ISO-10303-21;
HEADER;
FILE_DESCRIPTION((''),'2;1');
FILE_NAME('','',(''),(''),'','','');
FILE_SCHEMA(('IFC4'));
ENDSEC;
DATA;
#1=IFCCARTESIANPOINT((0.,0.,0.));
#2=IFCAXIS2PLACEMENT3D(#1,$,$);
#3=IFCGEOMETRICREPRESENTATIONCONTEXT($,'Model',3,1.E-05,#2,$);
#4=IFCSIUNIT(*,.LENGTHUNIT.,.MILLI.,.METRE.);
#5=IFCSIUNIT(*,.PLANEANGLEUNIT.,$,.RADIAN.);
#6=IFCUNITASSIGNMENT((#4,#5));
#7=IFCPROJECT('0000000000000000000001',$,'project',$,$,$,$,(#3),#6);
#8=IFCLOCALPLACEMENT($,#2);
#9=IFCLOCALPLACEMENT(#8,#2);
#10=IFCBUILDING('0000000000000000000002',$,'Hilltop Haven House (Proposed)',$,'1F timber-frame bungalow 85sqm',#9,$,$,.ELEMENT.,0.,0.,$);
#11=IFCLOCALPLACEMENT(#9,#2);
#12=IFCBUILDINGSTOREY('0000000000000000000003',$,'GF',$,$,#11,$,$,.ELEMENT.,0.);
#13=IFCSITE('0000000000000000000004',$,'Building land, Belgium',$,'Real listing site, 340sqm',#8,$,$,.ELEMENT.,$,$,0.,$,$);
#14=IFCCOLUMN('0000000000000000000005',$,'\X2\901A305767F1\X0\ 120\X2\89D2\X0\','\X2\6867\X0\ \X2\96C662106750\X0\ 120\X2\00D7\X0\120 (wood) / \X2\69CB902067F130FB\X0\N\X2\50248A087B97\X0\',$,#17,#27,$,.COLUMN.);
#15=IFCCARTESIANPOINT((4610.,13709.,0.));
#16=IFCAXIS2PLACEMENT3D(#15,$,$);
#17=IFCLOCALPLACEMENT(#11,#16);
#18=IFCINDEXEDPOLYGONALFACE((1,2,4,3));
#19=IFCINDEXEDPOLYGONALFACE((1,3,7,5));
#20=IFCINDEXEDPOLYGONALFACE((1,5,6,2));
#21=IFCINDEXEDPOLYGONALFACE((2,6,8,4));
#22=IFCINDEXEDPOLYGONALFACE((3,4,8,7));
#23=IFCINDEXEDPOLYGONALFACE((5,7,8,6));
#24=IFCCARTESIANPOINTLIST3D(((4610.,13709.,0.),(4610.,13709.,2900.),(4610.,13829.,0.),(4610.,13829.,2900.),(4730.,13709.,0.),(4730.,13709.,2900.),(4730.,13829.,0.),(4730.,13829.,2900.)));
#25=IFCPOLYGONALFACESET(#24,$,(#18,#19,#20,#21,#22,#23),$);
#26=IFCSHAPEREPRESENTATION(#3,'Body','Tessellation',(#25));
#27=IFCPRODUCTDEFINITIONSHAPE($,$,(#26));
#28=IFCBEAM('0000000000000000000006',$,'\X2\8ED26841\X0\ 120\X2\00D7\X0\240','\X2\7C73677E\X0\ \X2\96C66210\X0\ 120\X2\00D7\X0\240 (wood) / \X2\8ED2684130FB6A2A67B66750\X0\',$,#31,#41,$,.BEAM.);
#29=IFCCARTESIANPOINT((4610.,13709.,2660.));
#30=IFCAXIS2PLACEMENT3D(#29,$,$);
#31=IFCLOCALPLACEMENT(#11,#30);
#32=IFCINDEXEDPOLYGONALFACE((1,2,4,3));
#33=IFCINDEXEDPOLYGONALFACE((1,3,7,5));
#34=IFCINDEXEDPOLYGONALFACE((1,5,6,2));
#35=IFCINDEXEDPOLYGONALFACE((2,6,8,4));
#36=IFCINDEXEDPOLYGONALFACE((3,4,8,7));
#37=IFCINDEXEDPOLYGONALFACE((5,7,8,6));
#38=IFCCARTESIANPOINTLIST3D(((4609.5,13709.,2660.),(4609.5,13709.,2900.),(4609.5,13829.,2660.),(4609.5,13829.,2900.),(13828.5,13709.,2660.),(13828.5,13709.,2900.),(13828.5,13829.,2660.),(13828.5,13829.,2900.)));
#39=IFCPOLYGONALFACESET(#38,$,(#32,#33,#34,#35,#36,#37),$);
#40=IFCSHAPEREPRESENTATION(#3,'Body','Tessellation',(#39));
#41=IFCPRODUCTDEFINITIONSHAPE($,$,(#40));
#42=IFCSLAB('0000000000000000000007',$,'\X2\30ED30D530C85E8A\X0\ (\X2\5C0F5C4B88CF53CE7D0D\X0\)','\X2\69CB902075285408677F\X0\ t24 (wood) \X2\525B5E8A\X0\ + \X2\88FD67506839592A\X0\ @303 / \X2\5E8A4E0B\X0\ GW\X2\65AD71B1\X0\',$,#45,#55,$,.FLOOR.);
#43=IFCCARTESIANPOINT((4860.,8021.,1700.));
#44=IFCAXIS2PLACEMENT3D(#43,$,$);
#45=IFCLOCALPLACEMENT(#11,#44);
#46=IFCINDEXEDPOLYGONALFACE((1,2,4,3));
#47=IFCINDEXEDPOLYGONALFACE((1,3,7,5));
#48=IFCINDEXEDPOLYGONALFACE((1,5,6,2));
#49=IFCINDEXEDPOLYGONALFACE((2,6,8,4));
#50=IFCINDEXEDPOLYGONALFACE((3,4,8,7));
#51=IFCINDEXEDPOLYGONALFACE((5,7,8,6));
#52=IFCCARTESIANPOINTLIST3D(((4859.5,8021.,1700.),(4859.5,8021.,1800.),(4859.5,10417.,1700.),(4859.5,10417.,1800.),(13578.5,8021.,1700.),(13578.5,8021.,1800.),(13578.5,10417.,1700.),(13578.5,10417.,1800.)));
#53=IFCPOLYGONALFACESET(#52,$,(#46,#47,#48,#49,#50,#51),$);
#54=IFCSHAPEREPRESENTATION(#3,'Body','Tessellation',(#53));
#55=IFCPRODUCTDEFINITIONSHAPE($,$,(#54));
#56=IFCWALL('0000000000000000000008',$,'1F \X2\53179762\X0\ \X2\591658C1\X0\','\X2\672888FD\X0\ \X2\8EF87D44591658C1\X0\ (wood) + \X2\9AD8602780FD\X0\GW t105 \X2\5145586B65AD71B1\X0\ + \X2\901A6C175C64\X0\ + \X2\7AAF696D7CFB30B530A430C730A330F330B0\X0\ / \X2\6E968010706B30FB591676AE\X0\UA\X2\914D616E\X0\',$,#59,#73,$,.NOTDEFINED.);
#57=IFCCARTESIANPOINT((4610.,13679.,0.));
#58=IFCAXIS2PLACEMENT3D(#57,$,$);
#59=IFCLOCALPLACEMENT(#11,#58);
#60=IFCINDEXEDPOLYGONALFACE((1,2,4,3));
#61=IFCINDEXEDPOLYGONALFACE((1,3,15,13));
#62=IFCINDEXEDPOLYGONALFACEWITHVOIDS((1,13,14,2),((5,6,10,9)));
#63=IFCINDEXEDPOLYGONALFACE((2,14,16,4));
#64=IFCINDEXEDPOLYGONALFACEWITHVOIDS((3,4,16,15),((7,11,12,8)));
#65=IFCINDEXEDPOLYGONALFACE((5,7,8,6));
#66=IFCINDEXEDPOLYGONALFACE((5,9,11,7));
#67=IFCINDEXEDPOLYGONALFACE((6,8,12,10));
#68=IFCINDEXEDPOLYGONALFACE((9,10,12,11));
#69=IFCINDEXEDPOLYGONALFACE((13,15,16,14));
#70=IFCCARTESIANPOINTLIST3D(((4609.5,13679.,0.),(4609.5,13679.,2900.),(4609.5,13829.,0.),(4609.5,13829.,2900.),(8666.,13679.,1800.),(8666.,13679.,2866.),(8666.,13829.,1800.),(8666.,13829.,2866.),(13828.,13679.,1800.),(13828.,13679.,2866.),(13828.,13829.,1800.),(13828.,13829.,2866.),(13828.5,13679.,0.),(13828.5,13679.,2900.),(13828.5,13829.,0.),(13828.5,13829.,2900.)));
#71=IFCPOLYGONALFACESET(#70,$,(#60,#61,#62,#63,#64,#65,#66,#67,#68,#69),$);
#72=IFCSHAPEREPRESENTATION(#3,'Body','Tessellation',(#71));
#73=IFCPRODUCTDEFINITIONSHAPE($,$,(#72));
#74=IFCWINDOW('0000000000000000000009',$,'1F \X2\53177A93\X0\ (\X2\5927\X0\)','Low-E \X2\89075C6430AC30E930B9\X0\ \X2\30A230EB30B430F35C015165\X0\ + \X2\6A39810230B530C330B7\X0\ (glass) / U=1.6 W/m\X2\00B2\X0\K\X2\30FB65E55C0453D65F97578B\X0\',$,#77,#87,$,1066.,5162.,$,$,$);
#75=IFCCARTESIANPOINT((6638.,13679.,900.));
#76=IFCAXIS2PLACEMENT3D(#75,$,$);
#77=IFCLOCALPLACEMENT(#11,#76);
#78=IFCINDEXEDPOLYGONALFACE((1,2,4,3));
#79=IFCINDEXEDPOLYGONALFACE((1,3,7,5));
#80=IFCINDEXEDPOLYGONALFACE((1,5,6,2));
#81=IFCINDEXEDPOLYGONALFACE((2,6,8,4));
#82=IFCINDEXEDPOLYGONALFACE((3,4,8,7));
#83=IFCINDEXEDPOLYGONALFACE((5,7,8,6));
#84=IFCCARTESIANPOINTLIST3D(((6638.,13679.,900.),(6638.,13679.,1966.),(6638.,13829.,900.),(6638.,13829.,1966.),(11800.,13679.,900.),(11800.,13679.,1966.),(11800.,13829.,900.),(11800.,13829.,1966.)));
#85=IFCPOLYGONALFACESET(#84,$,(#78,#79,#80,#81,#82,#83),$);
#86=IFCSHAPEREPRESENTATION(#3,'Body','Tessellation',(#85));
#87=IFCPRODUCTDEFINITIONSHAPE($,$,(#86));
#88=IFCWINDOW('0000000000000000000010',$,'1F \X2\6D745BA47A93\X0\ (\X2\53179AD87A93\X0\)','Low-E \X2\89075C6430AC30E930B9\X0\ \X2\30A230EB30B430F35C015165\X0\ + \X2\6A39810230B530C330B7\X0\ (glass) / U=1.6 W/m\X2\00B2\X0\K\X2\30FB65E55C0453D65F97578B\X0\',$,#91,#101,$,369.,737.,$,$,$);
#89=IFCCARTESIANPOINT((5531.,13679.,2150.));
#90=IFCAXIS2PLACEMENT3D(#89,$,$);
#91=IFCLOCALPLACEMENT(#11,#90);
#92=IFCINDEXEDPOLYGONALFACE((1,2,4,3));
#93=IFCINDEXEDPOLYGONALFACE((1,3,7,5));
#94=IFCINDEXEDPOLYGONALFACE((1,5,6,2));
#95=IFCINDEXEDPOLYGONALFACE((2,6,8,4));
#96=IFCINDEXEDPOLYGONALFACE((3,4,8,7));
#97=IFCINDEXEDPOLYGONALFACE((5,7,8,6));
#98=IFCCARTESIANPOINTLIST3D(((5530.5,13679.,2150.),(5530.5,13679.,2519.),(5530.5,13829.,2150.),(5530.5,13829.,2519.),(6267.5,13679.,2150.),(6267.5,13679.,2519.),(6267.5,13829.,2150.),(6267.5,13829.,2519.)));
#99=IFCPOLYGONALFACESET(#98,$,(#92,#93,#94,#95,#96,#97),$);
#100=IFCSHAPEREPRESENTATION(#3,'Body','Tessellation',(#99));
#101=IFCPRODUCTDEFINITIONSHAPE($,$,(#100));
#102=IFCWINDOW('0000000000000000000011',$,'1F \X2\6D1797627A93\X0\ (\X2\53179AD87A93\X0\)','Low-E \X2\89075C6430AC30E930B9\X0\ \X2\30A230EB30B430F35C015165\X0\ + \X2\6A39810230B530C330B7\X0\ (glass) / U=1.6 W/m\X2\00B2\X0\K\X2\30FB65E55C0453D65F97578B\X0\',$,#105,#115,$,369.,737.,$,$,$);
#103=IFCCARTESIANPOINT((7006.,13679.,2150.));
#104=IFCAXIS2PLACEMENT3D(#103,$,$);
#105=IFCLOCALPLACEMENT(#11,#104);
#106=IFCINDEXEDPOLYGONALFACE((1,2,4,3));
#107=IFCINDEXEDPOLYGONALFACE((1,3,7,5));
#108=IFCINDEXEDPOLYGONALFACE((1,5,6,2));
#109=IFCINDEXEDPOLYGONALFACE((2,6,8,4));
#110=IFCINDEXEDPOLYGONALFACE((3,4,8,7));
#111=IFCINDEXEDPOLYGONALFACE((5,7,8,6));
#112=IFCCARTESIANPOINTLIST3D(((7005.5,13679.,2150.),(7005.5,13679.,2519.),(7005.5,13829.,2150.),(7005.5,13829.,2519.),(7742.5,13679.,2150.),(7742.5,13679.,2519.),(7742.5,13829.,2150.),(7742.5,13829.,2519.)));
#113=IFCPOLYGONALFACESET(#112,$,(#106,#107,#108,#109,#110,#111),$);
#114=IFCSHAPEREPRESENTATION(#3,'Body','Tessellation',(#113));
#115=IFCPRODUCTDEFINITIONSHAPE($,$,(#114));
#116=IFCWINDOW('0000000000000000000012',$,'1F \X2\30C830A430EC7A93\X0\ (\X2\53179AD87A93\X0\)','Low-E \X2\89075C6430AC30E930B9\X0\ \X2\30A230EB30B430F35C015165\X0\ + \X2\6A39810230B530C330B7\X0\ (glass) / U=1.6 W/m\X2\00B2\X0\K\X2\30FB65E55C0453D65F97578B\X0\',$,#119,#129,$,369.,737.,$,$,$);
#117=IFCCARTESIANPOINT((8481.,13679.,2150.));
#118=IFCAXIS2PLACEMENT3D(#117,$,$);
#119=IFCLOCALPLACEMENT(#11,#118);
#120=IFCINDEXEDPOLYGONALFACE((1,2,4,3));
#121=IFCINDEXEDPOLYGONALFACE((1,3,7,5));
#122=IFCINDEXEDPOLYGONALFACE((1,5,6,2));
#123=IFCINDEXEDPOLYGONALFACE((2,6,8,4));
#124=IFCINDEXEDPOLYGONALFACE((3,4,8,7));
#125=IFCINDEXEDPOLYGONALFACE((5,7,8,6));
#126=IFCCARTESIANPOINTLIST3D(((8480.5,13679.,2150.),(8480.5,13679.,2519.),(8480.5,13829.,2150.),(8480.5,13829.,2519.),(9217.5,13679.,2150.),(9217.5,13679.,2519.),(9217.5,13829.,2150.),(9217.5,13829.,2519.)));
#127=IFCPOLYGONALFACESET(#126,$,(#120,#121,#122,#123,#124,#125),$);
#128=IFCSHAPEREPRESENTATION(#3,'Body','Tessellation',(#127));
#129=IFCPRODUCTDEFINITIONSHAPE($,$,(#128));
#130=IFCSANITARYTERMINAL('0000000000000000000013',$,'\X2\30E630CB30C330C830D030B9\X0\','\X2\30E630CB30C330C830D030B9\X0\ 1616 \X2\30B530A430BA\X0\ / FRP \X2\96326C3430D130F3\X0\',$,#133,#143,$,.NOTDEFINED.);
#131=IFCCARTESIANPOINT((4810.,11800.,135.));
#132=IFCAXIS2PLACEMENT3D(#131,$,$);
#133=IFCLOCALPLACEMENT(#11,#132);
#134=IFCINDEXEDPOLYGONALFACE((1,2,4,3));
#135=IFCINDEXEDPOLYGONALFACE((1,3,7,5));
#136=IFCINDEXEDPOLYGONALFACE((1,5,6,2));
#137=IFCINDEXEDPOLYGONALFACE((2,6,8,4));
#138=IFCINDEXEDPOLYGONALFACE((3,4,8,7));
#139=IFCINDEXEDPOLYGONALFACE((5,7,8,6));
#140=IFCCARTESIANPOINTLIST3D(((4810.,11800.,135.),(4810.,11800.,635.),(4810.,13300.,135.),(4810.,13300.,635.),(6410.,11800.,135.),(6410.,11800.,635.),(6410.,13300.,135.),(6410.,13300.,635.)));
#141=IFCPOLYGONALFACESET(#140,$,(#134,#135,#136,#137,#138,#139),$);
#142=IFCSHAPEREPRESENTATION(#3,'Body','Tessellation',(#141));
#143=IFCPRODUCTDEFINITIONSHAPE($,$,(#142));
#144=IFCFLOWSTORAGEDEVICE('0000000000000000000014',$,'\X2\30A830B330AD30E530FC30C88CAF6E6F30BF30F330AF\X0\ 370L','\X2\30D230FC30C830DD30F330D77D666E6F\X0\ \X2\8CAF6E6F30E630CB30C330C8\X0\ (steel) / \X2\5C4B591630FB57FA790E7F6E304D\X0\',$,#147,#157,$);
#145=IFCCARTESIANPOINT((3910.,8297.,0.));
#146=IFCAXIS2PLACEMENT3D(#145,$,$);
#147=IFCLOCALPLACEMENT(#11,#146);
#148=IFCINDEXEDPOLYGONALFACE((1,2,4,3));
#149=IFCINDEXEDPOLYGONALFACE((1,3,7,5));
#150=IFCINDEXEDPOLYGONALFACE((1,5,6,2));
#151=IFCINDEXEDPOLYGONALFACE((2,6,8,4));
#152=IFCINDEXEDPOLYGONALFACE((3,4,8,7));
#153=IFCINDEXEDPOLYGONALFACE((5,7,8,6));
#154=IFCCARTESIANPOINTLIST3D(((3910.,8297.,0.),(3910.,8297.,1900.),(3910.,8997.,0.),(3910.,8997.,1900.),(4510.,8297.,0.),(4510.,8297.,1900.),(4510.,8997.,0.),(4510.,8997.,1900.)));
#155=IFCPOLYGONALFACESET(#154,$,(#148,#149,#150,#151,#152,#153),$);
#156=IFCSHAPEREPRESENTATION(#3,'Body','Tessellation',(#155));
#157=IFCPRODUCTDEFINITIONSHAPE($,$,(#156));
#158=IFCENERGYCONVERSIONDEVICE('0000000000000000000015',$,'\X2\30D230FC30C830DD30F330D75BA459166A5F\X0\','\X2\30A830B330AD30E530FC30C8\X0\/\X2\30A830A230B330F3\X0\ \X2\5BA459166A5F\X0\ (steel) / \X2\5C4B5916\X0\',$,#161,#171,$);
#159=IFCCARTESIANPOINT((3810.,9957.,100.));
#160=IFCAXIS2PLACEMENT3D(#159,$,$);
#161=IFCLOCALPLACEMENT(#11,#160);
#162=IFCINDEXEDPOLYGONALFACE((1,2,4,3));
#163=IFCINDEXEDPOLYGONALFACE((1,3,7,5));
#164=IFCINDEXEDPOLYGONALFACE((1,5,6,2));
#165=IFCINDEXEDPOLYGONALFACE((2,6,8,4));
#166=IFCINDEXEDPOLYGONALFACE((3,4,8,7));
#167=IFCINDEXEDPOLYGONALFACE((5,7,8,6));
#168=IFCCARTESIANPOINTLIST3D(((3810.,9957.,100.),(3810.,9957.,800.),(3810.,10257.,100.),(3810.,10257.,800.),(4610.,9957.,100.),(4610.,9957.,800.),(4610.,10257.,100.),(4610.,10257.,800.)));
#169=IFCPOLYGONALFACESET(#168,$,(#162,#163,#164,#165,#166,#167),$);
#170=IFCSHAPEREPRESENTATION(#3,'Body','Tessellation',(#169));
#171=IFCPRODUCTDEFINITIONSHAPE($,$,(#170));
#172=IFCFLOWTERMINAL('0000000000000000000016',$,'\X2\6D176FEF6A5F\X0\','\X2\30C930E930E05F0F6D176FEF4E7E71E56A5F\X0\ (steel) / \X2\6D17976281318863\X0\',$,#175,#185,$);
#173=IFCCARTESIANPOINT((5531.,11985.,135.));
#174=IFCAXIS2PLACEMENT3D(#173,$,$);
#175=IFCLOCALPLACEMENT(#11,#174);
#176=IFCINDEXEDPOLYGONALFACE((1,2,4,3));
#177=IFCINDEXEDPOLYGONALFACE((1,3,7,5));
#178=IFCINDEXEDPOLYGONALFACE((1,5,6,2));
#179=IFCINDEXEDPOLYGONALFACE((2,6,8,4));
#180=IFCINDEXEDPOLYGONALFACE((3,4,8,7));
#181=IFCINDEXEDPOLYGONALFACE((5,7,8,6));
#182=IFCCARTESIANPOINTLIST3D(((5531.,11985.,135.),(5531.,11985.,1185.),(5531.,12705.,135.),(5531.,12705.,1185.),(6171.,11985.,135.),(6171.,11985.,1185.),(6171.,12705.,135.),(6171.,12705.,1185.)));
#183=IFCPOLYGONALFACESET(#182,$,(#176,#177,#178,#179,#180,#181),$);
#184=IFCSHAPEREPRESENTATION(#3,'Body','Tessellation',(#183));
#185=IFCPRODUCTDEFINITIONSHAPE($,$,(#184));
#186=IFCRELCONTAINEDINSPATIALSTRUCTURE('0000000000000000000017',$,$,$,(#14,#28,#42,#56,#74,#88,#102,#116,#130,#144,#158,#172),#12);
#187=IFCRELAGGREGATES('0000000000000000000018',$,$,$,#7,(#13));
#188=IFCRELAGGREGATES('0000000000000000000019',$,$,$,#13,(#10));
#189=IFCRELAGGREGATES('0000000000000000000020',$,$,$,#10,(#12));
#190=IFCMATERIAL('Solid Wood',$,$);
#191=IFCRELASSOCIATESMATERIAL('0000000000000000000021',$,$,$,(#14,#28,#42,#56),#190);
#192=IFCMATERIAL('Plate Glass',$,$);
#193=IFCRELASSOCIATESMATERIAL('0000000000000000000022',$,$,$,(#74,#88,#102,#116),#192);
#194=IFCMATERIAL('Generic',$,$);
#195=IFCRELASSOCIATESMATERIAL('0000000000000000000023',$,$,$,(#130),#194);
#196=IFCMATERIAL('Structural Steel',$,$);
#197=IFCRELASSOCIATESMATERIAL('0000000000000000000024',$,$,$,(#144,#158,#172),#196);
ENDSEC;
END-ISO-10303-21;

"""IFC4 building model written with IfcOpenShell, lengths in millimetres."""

from ifc_helpers import new_model, si_unit, frame, frame_2d, origin, place, context, project, spatial, rectangle, extrude, material, element, fill, save


model = new_model("IFC4")

# Units and contexts
model_context = context("Model", 3, precision=1e-05, world=origin())
ifc_project = project(units=[si_unit("LENGTHUNIT", "METRE", prefix="MILLI"), si_unit("PLANEANGLEUNIT", "RADIAN")], contexts=[model_context])

# Site, building, storey
site_placement = place(None, origin())
site = spatial("IfcSite", under=ifc_project, at=site_placement, Name="Building land, Belgium", ObjectType="Real listing site, 340sqm", CompositionType="ELEMENT", RefElevation=0.0)
building_placement = place(site_placement, origin())
building = spatial("IfcBuilding", under=site, at=building_placement, Name="Hilltop Haven House (Proposed)", ObjectType="1F timber-frame bungalow 85sqm", CompositionType="ELEMENT", ElevationOfRefHeight=0.0, ElevationOfTerrain=0.0)
storey_placement = place(building_placement, origin())
storey = spatial("IfcBuildingStorey", under=building, at=storey_placement, Name="GF", CompositionType="ELEMENT", Elevation=0.0)

# Column
ifc_material_1 = material(Name="Solid Wood")
column_1_placement = place(storey_placement, frame((4610.0, 13709.0, 0.0)))
element("IfcColumn", 1, at=column_1_placement, inside=storey, material=ifc_material_1, Name="通し柱 120角", Description="桧 集成材 120×120 (wood) / 構造柱・N値計算", PredefinedType="COLUMN", context=model_context, shape_type="SweptSolid", body=[
    extrude(rectangle(XDim=120.0, YDim=120.0, at=frame_2d((60.0, 60.0))), frame((4610.0, 13709.0, 0.0)), (0.0, 0.0, 1.0), 2900.0),
])

# Beam
beam_1_placement = place(storey_placement, frame((4610.0, 13709.0, 2660.0)))
element("IfcBeam", 2, at=beam_1_placement, inside=storey, material=ifc_material_1, Name="軒桁 120×240", Description="米松 集成 120×240 (wood) / 軒桁・横架材", PredefinedType="BEAM", context=model_context, shape_type="SweptSolid", body=[
    extrude(rectangle(XDim=9219.0, YDim=120.0, at=frame_2d((4609.0, 60.0))), frame((4610.0, 13709.0, 2660.0)), (0.0, 0.0, 1.0), 240.0),
])

# Slab
slab_placement = place(storey_placement, frame((4860.0, 8021.0, 1700.0)))
element("IfcSlab", 3, at=slab_placement, inside=storey, material=ifc_material_1, Name="ロフト床 (小屋裏収納)", Description="構造用合板 t24 (wood) 剛床 + 製材根太 @303 / 床下 GW断熱", PredefinedType="FLOOR", context=model_context, shape_type="SweptSolid", body=[
    extrude(rectangle(XDim=8719.0, YDim=2396.0, at=frame_2d((4359.0, 1198.0))), frame((4860.0, 8021.0, 1700.0)), (0.0, 0.0, 1.0), 100.0),
])

# Wall, openings, windows
wall_1_placement = place(storey_placement, frame((4610.0, 13679.0, 0.0)))
wall_1 = element("IfcWall", 4, at=wall_1_placement, inside=storey, material=ifc_material_1, Name="1F 北面 外壁", Description="木製 軸組外壁 (wood) + 高性能GW t105 充填断熱 + 通気層 + 窯業系サイディング / 準耐火・外皮UA配慮", PredefinedType="NOTDEFINED", context=model_context, shape_type="SweptSolid", body=[
    extrude(rectangle(XDim=9219.0, YDim=150.0, at=frame_2d((4609.0, 75.0))), frame((4610.0, 13679.0, 0.0)), (0.0, 0.0, 1.0), 2900.0),
])
opening_1_placement = place(storey_placement, frame((6638.0, 13679.0, 900.0)))
opening_1 = element("IfcOpeningElement", 5, at=opening_1_placement, cuts=wall_1, PredefinedType="NOTDEFINED", context=model_context, shape_type="SweptSolid", body=[
    extrude(rectangle(XDim=5162.0, YDim=150.0, at=frame_2d((2581.0, 75.0))), frame((6638.0, 13679.0, 900.0)), (0.0, 0.0, 1.0), 1066.0),
])
opening_2_placement = place(storey_placement, frame((5531.0, 13679.0, 2150.0)))
opening_2 = element("IfcOpeningElement", 6, at=opening_2_placement, cuts=wall_1, PredefinedType="NOTDEFINED", context=model_context, shape_type="SweptSolid", body=[
    extrude(rectangle(XDim=737.0, YDim=150.0, at=frame_2d((368.0, 75.0))), frame((5531.0, 13679.0, 2150.0)), (0.0, 0.0, 1.0), 369.0),
])
opening_3_placement = place(storey_placement, frame((7006.0, 13679.0, 2150.0)))
opening_3 = element("IfcOpeningElement", 7, at=opening_3_placement, cuts=wall_1, PredefinedType="NOTDEFINED", context=model_context, shape_type="SweptSolid", body=[
    extrude(rectangle(XDim=737.0, YDim=150.0, at=frame_2d((368.0, 75.0))), frame((7006.0, 13679.0, 2150.0)), (0.0, 0.0, 1.0), 369.0),
])
opening_4_placement = place(storey_placement, frame((8481.0, 13679.0, 2150.0)))
opening_4 = element("IfcOpeningElement", 8, at=opening_4_placement, cuts=wall_1, PredefinedType="NOTDEFINED", context=model_context, shape_type="SweptSolid", body=[
    extrude(rectangle(XDim=737.0, YDim=150.0, at=frame_2d((368.0, 75.0))), frame((8481.0, 13679.0, 2150.0)), (0.0, 0.0, 1.0), 369.0),
])
ifc_material_2 = material(Name="Plate Glass")
window_1_placement = place(storey_placement, frame((6638.0, 13679.0, 900.0)))
window_1 = element("IfcWindow", 9, at=window_1_placement, inside=storey, material=ifc_material_2, Name="1F 北窓 (大)", Description="Low-E 複層ガラス アルゴン封入 + 樹脂サッシ (glass) / U=1.6 W/m²K・日射取得型", OverallHeight=1066.0, OverallWidth=5162.0, context=model_context, shape_type="SweptSolid", body=[
    extrude(rectangle(XDim=5162.0, YDim=150.0, at=frame_2d((2581.0, 75.0))), frame((6638.0, 13679.0, 900.0)), (0.0, 0.0, 1.0), 1066.0),
])
fill(opening_1, window_1)
window_2_placement = place(storey_placement, frame((5531.0, 13679.0, 2150.0)))
window_2 = element("IfcWindow", 10, at=window_2_placement, inside=storey, material=ifc_material_2, Name="1F 浴室窓 (北高窓)", Description="Low-E 複層ガラス アルゴン封入 + 樹脂サッシ (glass) / U=1.6 W/m²K・日射取得型", OverallHeight=369.0, OverallWidth=737.0, context=model_context, shape_type="SweptSolid", body=[
    extrude(rectangle(XDim=737.0, YDim=150.0, at=frame_2d((368.0, 75.0))), frame((5531.0, 13679.0, 2150.0)), (0.0, 0.0, 1.0), 369.0),
])
fill(opening_2, window_2)
window_3_placement = place(storey_placement, frame((7006.0, 13679.0, 2150.0)))
window_3 = element("IfcWindow", 11, at=window_3_placement, inside=storey, material=ifc_material_2, Name="1F 洗面窓 (北高窓)", Description="Low-E 複層ガラス アルゴン封入 + 樹脂サッシ (glass) / U=1.6 W/m²K・日射取得型", OverallHeight=369.0, OverallWidth=737.0, context=model_context, shape_type="SweptSolid", body=[
    extrude(rectangle(XDim=737.0, YDim=150.0, at=frame_2d((368.0, 75.0))), frame((7006.0, 13679.0, 2150.0)), (0.0, 0.0, 1.0), 369.0),
])
fill(opening_3, window_3)
window_4_placement = place(storey_placement, frame((8481.0, 13679.0, 2150.0)))
window_4 = element("IfcWindow", 12, at=window_4_placement, inside=storey, material=ifc_material_2, Name="1F トイレ窓 (北高窓)", Description="Low-E 複層ガラス アルゴン封入 + 樹脂サッシ (glass) / U=1.6 W/m²K・日射取得型", OverallHeight=369.0, OverallWidth=737.0, context=model_context, shape_type="SweptSolid", body=[
    extrude(rectangle(XDim=737.0, YDim=150.0, at=frame_2d((368.0, 75.0))), frame((8481.0, 13679.0, 2150.0)), (0.0, 0.0, 1.0), 369.0),
])
fill(opening_4, window_4)

# Sanitary terminal
ifc_material_3 = material(Name="Generic")
sanitary_terminal_placement = place(storey_placement, frame((4810.0, 11800.0, 135.0)))
element("IfcSanitaryTerminal", 13, at=sanitary_terminal_placement, inside=storey, material=ifc_material_3, Name="ユニットバス", Description="ユニットバス 1616 サイズ / FRP 防水パン", PredefinedType="NOTDEFINED", context=model_context, shape_type="SweptSolid", body=[
    extrude(rectangle(XDim=1600.0, YDim=1500.0, at=frame_2d((800.0, 750.0))), frame((4810.0, 11800.0, 135.0)), (0.0, 0.0, 1.0), 500.0),
])

# Flow storage device
ifc_material_4 = material(Name="Structural Steel")
flow_storage_device_placement = place(storey_placement, frame((3910.0, 8297.0, 0.0)))
element("IfcFlowStorageDevice", 14, at=flow_storage_device_placement, inside=storey, material=ifc_material_4, Name="エコキュート貯湯タンク 370L", Description="ヒートポンプ給湯 貯湯ユニット (steel) / 屋外・基礎置き", context=model_context, shape_type="SweptSolid", body=[
    extrude(rectangle(XDim=600.0, YDim=700.0, at=frame_2d((300.0, 350.0))), frame((3910.0, 8297.0, 0.0)), (0.0, 0.0, 1.0), 1900.0),
])

# Energy conversion device
energy_conversion_device_placement = place(storey_placement, frame((3810.0, 9957.0, 100.0)))
element("IfcEnergyConversionDevice", 15, at=energy_conversion_device_placement, inside=storey, material=ifc_material_4, Name="ヒートポンプ室外機", Description="エコキュート/エアコン 室外機 (steel) / 屋外", context=model_context, shape_type="SweptSolid", body=[
    extrude(rectangle(XDim=800.0, YDim=300.0, at=frame_2d((400.0, 150.0))), frame((3810.0, 9957.0, 100.0)), (0.0, 0.0, 1.0), 700.0),
])

# Flow terminal
flow_terminal_placement = place(storey_placement, frame((5531.0, 11985.0, 135.0)))
element("IfcFlowTerminal", 16, at=flow_terminal_placement, inside=storey, material=ifc_material_4, Name="洗濯機", Description="ドラム式洗濯乾燥機 (steel) / 洗面脱衣", context=model_context, shape_type="SweptSolid", body=[
    extrude(rectangle(XDim=640.0, YDim=720.0, at=frame_2d((320.0, 360.0))), frame((5531.0, 11985.0, 135.0)), (0.0, 0.0, 1.0), 1050.0),
])

save(model, "model.ifc")
